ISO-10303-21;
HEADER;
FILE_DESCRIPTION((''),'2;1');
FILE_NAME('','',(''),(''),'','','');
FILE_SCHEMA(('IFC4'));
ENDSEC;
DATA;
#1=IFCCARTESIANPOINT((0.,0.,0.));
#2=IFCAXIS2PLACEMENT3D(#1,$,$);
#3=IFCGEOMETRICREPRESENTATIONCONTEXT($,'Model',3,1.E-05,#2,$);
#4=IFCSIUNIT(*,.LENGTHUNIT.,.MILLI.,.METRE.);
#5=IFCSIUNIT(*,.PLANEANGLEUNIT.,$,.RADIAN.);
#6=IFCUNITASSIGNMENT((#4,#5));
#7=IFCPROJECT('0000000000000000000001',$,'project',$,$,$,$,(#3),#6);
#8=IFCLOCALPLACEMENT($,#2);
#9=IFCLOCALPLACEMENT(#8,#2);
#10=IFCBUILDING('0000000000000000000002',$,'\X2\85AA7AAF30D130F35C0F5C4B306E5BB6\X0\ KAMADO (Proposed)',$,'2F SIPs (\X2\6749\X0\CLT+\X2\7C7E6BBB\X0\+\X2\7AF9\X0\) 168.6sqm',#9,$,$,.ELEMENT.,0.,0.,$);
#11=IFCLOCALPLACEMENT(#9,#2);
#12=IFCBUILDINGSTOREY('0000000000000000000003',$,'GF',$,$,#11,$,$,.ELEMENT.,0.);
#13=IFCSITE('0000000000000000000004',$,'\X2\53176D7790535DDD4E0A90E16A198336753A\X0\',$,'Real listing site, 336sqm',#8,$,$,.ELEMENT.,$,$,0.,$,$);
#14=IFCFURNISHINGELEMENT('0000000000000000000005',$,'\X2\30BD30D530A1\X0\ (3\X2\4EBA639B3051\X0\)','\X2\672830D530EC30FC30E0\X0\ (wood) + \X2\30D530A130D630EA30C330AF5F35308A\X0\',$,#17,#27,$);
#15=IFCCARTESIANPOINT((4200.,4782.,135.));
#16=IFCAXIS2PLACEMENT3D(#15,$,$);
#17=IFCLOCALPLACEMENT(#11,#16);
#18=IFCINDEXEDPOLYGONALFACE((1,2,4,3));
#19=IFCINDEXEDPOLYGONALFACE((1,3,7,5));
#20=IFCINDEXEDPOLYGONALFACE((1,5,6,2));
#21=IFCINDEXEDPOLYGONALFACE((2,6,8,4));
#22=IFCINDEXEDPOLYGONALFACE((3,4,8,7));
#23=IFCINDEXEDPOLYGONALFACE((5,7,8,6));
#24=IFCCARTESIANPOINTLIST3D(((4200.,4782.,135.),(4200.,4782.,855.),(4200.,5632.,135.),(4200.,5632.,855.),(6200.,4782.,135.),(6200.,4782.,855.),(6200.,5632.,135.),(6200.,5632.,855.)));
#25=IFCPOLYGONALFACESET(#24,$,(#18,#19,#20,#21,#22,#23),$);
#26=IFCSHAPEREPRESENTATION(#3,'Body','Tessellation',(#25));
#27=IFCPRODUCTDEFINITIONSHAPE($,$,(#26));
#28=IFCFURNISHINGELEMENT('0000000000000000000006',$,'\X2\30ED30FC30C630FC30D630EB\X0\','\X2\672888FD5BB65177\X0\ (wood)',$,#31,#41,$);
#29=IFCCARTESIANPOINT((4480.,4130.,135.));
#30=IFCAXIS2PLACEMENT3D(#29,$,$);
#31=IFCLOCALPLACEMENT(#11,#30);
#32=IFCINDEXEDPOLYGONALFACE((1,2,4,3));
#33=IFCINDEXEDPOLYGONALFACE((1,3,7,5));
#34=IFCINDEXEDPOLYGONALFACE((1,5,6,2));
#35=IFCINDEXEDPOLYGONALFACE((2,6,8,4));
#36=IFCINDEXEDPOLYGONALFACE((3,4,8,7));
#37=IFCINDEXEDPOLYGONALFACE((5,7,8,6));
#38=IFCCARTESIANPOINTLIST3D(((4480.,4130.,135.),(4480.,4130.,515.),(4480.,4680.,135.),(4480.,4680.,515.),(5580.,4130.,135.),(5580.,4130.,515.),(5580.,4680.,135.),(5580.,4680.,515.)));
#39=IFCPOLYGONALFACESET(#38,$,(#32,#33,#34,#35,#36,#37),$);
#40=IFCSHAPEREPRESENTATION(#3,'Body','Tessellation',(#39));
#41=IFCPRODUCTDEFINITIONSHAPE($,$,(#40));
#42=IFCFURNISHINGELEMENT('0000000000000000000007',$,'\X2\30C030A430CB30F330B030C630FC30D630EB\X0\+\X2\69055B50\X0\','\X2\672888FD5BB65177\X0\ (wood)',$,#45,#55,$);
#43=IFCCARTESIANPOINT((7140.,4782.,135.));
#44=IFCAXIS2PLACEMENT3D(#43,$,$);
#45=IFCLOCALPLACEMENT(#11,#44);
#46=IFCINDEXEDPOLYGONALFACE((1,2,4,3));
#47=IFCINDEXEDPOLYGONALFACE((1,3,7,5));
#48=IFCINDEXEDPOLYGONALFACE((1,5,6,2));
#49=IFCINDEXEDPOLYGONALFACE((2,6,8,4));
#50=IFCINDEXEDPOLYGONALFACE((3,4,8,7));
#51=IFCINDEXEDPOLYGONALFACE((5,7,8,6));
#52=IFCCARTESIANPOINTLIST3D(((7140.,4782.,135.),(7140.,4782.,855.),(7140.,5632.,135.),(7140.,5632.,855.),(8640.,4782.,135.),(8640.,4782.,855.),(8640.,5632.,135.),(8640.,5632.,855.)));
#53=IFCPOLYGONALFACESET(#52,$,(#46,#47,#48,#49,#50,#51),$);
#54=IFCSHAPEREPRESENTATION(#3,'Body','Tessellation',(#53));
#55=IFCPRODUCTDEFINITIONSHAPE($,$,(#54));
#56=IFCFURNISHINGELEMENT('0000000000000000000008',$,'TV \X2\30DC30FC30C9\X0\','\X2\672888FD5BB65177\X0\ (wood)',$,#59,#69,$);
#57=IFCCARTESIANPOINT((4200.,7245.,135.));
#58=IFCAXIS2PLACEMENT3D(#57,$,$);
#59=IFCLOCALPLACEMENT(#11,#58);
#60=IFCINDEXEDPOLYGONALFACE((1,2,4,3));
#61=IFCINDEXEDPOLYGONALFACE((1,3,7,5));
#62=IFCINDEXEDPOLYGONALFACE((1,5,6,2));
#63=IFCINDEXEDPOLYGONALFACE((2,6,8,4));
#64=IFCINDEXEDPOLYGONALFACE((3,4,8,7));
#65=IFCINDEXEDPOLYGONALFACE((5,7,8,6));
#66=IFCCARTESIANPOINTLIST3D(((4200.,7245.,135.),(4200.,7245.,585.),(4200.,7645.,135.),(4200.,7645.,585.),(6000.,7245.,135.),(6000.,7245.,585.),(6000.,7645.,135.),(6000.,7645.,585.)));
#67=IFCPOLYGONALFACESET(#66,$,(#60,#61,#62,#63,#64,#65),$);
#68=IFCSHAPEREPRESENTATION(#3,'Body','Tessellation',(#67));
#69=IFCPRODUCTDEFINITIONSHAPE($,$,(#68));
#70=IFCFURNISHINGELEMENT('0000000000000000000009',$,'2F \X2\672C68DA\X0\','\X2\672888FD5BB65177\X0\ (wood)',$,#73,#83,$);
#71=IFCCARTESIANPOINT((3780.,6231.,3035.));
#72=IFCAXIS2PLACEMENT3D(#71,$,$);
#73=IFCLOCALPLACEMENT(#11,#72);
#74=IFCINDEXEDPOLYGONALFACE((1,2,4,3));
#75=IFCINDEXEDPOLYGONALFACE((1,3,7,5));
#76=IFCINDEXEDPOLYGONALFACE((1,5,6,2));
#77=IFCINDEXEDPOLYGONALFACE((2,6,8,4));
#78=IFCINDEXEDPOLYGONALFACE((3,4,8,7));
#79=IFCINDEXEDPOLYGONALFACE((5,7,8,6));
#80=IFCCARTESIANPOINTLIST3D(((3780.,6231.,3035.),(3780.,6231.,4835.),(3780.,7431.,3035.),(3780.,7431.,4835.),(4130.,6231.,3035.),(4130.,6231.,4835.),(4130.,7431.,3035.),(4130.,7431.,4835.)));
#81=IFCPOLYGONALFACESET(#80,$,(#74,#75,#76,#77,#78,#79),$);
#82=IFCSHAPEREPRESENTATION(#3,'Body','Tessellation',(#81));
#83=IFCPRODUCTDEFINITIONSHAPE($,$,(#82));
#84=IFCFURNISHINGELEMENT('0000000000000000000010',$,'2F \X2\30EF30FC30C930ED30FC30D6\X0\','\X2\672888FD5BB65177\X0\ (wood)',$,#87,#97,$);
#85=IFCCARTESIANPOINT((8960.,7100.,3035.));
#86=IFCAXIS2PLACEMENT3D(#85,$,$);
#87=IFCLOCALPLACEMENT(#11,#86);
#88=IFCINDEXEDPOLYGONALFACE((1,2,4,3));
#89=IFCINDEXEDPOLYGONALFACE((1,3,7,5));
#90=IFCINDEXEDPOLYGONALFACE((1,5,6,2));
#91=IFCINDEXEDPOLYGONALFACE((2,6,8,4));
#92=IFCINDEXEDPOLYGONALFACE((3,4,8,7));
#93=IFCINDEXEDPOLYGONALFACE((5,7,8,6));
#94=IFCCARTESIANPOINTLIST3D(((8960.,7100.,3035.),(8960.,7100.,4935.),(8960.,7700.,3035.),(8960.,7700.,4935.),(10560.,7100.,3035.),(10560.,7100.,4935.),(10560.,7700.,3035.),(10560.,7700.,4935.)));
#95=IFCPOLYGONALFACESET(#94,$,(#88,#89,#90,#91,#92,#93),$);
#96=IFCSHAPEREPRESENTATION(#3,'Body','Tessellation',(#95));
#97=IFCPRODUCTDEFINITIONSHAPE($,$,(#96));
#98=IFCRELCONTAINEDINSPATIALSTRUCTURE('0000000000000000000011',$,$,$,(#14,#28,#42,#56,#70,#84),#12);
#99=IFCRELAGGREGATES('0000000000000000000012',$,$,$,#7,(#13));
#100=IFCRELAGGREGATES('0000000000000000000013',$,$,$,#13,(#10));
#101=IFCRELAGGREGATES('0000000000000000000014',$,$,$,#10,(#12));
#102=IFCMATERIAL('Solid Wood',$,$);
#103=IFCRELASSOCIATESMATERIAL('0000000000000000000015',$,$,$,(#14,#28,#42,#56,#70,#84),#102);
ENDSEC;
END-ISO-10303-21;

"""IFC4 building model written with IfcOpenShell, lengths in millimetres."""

from ifc_helpers import new_model, si_unit, frame, frame_2d, origin, place, context, project, spatial, rectangle, extrude, material, element, save


model = new_model("IFC4")

# Units and contexts
model_context = context("Model", 3, precision=1e-05, world=origin())
ifc_project = project(units=[si_unit("LENGTHUNIT", "METRE", prefix="MILLI"), si_unit("PLANEANGLEUNIT", "RADIAN")], contexts=[model_context])

# Site, building, storey
site_placement = place(None, origin())
site = spatial("IfcSite", under=ifc_project, at=site_placement, Name="北海道川上郡標茶町", ObjectType="Real listing site, 336sqm", CompositionType="ELEMENT", RefElevation=0.0)
building_placement = place(site_placement, origin())
building = spatial("IfcBuilding", under=site, at=building_placement, Name="薪窯パン小屋の家 KAMADO (Proposed)", ObjectType="2F SIPs (杉CLT+籾殻+竹) 168.6sqm", CompositionType="ELEMENT", ElevationOfRefHeight=0.0, ElevationOfTerrain=0.0)
storey_placement = place(building_placement, origin())
storey = spatial("IfcBuildingStorey", under=building, at=storey_placement, Name="GF", CompositionType="ELEMENT", Elevation=0.0)

# Shared definitions
ifc_material_1 = material(Name="Solid Wood")

# Furnishing elements
furnishing_1_placement = place(storey_placement, frame((4200.0, 4782.0, 135.0)))
element("IfcFurnishingElement", 1, at=furnishing_1_placement, inside=storey, material=ifc_material_1, Name="ソファ (3人掛け)", Description="木フレーム (wood) + ファブリック張り", context=model_context, shape_type="SweptSolid", body=[
    extrude(rectangle(XDim=2000.0, YDim=850.0, at=frame_2d((1000.0, 425.0))), frame((4200.0, 4782.0, 135.0)), (0.0, 0.0, 1.0), 720.0),
])
furnishing_2_placement = place(storey_placement, frame((4480.0, 4130.0, 135.0)))
element("IfcFurnishingElement", 2, at=furnishing_2_placement, inside=storey, material=ifc_material_1, Name="ローテーブル", Description="木製家具 (wood)", context=model_context, shape_type="SweptSolid", body=[
    extrude(rectangle(XDim=1100.0, YDim=550.0, at=frame_2d((550.0, 275.0))), frame((4480.0, 4130.0, 135.0)), (0.0, 0.0, 1.0), 380.0),
])
furnishing_3_placement = place(storey_placement, frame((7140.0, 4782.0, 135.0)))
element("IfcFurnishingElement", 3, at=furnishing_3_placement, inside=storey, material=ifc_material_1, Name="ダイニングテーブル+椅子", Description="木製家具 (wood)", context=model_context, shape_type="SweptSolid", body=[
    extrude(rectangle(XDim=1500.0, YDim=850.0, at=frame_2d((750.0, 425.0))), frame((7140.0, 4782.0, 135.0)), (0.0, 0.0, 1.0), 720.0),
])
furnishing_4_placement = place(storey_placement, frame((4200.0, 7245.0, 135.0)))
element("IfcFurnishingElement", 4, at=furnishing_4_placement, inside=storey, material=ifc_material_1, Name="TV ボード", Description="木製家具 (wood)", context=model_context, shape_type="SweptSolid", body=[
    extrude(rectangle(XDim=1800.0, YDim=400.0, at=frame_2d((900.0, 200.0))), frame((4200.0, 7245.0, 135.0)), (0.0, 0.0, 1.0), 450.0),
])
furnishing_5_placement = place(storey_placement, frame((3780.0, 6231.0, 3035.0)))
element("IfcFurnishingElement", 5, at=furnishing_5_placement, inside=storey, material=ifc_material_1, Name="2F 本棚", Description="木製家具 (wood)", context=model_context, shape_type="SweptSolid", body=[
    extrude(rectangle(XDim=350.0, YDim=1200.0, at=frame_2d((175.0, 600.0))), frame((3780.0, 6231.0, 3035.0)), (0.0, 0.0, 1.0), 1800.0),
])
furnishing_6_placement = place(storey_placement, frame((8960.0, 7100.0, 3035.0)))
element("IfcFurnishingElement", 6, at=furnishing_6_placement, inside=storey, material=ifc_material_1, Name="2F ワードローブ", Description="木製家具 (wood)", context=model_context, shape_type="SweptSolid", body=[
    extrude(rectangle(XDim=1600.0, YDim=600.0, at=frame_2d((800.0, 300.0))), frame((8960.0, 7100.0, 3035.0)), (0.0, 0.0, 1.0), 1900.0),
])

save(model, "model.ifc")
